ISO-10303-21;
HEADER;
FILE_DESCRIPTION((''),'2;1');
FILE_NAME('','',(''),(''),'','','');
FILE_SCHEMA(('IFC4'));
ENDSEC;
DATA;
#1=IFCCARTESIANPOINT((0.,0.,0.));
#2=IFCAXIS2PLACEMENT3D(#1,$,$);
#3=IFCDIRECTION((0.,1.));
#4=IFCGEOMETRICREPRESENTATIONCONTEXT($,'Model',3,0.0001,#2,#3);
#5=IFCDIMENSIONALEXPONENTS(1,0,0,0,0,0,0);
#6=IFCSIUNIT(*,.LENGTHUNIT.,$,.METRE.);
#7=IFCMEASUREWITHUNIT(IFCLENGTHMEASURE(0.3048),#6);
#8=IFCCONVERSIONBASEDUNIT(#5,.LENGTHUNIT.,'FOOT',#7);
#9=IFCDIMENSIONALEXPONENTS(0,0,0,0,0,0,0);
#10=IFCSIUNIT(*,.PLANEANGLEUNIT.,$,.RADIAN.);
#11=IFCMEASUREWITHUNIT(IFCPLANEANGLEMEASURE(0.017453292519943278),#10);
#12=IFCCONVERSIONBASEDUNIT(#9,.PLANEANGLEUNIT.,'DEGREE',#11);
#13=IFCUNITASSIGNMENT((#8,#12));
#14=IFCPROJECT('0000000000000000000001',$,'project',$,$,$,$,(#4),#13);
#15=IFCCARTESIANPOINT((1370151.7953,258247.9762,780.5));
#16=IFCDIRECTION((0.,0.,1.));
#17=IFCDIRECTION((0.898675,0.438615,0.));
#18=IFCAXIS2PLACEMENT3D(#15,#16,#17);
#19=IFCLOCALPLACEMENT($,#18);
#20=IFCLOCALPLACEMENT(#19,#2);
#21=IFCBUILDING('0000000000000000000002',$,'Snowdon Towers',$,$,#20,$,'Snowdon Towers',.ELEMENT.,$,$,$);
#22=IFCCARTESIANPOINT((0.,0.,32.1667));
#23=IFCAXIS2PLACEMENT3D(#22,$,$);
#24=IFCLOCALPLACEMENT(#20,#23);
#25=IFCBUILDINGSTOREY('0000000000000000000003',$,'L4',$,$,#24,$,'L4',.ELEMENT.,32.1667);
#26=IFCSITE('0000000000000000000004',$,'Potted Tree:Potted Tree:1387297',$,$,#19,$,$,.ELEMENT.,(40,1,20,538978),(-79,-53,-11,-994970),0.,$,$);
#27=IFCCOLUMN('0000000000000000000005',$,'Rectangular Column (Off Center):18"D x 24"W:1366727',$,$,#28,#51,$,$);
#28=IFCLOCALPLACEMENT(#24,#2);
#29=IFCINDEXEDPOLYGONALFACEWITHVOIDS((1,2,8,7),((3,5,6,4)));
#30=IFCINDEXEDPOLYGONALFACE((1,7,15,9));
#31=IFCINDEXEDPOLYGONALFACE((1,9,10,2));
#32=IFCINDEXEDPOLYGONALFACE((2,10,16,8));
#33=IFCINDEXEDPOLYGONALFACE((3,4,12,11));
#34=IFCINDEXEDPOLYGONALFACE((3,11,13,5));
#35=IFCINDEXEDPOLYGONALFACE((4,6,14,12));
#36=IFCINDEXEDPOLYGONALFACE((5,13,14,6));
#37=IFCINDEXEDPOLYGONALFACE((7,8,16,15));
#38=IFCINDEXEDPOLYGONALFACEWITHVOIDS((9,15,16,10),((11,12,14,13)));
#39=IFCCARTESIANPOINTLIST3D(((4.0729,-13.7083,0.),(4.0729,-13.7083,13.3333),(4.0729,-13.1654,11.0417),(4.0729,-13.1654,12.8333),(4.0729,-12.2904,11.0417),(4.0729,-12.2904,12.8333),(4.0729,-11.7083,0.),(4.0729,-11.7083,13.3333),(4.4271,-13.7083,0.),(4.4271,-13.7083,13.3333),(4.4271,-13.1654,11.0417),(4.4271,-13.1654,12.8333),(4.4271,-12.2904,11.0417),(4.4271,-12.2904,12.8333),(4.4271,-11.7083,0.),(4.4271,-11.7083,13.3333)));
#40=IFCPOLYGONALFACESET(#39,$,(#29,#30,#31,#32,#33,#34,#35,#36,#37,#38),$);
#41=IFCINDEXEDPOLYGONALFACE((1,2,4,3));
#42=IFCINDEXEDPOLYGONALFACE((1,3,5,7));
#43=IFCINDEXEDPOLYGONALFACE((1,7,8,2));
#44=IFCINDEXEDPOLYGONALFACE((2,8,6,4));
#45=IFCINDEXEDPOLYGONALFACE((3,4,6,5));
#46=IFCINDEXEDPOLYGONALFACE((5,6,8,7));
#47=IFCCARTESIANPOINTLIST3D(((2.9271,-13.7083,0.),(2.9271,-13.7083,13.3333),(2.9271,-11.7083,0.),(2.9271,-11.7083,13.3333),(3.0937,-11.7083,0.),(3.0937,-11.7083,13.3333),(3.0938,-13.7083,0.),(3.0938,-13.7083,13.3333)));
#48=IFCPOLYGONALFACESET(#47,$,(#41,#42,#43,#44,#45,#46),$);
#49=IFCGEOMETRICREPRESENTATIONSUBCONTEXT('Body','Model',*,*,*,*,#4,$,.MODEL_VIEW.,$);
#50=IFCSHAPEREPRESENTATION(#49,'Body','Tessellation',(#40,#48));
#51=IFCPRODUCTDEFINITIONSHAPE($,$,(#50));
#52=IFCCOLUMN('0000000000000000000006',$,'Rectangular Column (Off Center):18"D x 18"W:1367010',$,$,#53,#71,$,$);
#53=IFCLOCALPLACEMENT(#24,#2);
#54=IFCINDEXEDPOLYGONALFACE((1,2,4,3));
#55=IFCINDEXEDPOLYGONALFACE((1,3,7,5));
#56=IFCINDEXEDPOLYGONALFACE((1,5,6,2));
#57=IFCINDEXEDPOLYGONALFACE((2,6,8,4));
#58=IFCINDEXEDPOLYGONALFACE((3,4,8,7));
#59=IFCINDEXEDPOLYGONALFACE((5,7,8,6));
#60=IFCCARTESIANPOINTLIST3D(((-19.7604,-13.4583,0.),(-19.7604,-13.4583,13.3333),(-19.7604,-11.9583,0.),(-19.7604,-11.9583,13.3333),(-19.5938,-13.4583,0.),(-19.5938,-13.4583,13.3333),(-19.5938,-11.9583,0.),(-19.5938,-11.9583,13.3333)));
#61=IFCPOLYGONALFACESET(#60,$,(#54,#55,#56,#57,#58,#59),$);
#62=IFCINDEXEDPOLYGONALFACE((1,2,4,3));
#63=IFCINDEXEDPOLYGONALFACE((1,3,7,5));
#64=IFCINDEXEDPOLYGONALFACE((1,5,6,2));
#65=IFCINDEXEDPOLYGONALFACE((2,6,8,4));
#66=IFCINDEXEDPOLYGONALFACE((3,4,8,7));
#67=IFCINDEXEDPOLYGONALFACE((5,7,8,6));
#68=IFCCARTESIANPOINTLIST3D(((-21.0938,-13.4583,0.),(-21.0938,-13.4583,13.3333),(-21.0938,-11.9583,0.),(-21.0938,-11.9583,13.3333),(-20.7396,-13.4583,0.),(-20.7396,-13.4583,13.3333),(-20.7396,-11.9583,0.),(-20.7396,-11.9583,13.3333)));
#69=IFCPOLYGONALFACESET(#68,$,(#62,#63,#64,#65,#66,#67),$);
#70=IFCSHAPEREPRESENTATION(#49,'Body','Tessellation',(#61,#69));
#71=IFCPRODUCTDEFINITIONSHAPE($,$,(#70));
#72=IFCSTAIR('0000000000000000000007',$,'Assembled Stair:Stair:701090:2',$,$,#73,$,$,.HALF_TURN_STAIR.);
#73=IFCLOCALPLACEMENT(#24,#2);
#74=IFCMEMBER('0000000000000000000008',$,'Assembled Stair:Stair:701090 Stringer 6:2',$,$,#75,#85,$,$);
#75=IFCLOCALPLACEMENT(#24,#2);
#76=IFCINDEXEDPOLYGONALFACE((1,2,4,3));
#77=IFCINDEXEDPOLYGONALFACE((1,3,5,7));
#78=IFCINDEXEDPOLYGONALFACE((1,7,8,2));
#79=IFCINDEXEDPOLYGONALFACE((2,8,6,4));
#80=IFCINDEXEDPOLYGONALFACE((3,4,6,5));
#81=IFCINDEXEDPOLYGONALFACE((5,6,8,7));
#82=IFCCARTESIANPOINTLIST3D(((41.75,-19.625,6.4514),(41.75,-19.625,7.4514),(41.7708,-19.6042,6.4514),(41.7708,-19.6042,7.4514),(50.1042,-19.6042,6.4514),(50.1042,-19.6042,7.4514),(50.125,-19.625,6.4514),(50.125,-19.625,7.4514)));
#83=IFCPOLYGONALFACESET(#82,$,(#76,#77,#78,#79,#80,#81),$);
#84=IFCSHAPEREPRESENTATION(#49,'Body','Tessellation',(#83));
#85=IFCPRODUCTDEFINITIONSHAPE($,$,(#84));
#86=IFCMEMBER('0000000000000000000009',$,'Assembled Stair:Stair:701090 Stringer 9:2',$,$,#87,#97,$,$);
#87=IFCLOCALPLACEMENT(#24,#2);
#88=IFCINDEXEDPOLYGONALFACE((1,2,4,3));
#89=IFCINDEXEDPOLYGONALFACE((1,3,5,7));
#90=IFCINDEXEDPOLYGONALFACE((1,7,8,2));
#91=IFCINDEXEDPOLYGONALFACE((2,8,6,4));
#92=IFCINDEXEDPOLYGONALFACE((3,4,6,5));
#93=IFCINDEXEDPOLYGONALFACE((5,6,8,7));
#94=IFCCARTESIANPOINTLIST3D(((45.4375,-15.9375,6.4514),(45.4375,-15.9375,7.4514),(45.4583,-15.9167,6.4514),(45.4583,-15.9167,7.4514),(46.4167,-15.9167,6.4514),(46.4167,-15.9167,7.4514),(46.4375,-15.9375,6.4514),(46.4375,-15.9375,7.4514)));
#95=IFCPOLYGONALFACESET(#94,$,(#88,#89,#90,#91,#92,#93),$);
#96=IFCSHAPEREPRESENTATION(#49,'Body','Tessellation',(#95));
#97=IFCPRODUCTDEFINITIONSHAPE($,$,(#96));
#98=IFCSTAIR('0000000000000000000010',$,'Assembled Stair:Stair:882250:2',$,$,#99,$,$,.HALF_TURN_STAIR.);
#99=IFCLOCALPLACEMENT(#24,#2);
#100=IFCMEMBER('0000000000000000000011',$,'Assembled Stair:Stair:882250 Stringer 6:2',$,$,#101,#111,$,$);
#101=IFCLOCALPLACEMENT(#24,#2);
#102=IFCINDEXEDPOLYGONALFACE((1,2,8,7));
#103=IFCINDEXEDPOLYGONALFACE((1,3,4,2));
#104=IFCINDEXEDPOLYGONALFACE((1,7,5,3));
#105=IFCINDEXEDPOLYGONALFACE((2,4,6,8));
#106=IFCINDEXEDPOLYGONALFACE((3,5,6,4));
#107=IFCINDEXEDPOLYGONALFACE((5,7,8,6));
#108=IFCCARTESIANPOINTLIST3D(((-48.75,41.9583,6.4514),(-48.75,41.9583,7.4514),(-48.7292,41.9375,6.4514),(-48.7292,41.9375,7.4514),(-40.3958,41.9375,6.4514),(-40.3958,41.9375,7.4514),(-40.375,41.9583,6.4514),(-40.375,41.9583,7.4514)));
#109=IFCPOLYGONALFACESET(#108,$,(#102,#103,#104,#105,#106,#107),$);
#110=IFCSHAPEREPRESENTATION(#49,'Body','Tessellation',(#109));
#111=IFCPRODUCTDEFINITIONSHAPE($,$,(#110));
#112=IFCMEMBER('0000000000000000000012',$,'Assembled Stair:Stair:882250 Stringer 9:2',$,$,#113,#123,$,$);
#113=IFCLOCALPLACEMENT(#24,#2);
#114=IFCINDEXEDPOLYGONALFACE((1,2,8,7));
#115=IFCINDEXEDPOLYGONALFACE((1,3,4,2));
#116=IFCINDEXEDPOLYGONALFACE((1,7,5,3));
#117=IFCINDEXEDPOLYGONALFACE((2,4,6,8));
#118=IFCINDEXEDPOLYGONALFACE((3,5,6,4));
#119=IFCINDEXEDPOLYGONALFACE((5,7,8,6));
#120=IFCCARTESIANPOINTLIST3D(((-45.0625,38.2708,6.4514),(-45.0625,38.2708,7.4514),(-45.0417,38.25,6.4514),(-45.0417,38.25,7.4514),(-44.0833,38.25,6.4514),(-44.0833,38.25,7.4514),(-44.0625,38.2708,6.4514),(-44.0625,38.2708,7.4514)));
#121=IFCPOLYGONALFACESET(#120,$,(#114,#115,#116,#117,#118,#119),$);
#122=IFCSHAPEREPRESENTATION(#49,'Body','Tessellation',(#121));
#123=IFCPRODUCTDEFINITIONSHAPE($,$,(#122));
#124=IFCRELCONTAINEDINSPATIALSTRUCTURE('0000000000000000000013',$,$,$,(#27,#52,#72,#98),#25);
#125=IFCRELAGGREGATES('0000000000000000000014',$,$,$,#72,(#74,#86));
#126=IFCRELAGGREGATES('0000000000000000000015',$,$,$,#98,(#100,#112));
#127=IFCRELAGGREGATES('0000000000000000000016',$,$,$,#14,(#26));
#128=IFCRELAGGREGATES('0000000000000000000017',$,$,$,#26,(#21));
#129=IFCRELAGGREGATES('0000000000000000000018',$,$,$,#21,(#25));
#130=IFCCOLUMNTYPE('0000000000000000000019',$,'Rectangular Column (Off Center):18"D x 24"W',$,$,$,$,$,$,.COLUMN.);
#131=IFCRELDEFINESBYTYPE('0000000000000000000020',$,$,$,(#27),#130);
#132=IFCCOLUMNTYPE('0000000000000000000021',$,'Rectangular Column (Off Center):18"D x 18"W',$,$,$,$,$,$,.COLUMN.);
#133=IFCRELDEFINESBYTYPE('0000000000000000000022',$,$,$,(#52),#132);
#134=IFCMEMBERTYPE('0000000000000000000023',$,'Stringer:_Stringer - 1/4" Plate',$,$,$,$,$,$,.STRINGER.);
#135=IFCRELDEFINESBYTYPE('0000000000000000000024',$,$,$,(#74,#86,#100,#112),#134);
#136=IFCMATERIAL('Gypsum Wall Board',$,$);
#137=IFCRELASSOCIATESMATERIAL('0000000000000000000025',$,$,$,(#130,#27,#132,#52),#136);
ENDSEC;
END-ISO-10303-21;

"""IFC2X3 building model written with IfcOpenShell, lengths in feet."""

from ifc_helpers import new_model, entity, si_unit, converted_unit, direction, frame, frame_2d, origin, place, context, subcontext, project, spatial, polyline, rectangle, outline, extrude, source, transform, mapped, material, type_object, type_shapes, element, aggregate, save


model = new_model("IFC2X3")

# Units and contexts
model_context = context("Model", 3, precision=0.0001, world=origin(), true_north=direction((0.0, 1.0)))
body_context = subcontext(model_context, "Body", "Model", "MODEL_VIEW")
ifc_project = project(units=[converted_unit("LENGTHUNIT", "FOOT", entity("IfcLengthMeasure", 0.3048), si_unit("LENGTHUNIT", "METRE"), dimensions=[1, 0, 0, 0, 0, 0, 0]), converted_unit("PLANEANGLEUNIT", "DEGREE", entity("IfcPlaneAngleMeasure", 0.017453292519943278), si_unit("PLANEANGLEUNIT", "RADIAN"), dimensions=[0, 0, 0, 0, 0, 0, 0])], contexts=[model_context])

# Site, building, storey
site_placement = place(None, frame((1370151.7953, 258247.9762, 780.5), z_axis=(0.0, 0.0, 1.0), x_axis=(0.898675, 0.438615, 0.0)))
site = spatial("IfcSite", under=ifc_project, at=site_placement, Name="Potted Tree:Potted Tree:1387297", CompositionType="ELEMENT", RefLatitude=(40, 1, 20, 538978), RefLongitude=(-79, -53, -11, -994970), RefElevation=0.0)
building_placement = place(site_placement, origin())
building = spatial("IfcBuilding", under=site, at=building_placement, Name="Snowdon Towers", LongName="Snowdon Towers", CompositionType="ELEMENT")
storey_placement = place(building_placement, frame((0.0, 0.0, 32.1667)))
storey = spatial("IfcBuildingStorey", under=building, at=storey_placement, Name="L4", LongName="L4", CompositionType="ELEMENT", Elevation=32.1667)

# Shared definitions
ifc_material = material(Name="Gypsum Wall Board")

# Column, opening
column_type_1 = type_object("IfcColumnType", Name="Rectangular Column (Off Center):18\"D x 24\"W", PredefinedType="COLUMN", material=ifc_material)
shared_shape_1 = source(origin(), body_context, "Body", "SweptSolid", [
    extrude(rectangle(XDim=0.3542, YDim=2.0, at=frame_2d((0.0, 0.0), x_axis=(1.0, 0.0))), frame((4.25, -12.7083, 32.1667), z_axis=(0.0, 0.0, 1.0), x_axis=(-1.0, 0.0, 0.0)), (0.0, 0.0, 1.0), 13.3333),
    extrude(rectangle(XDim=0.1667, YDim=2.0, at=frame_2d((0.0, 0.0), x_axis=(1.0, 0.0))), frame((3.0104, -12.7083, 32.1667)), (0.0, 0.0, 1.0), 13.3333),
])
type_shapes(column_type_1, [shared_shape_1])
column_1_placement = place(storey_placement, frame((0.0, 0.0, -32.1667)))
column_1 = element("IfcColumn", 1, at=column_1_placement, inside=storey, type_object=column_type_1, material=ifc_material, Name="Rectangular Column (Off Center):18\"D x 24\"W:1366727", context=body_context, shape_type="MappedRepresentation", body=[
    mapped(shared_shape_1, transform((0.0, 0.0, 0.0), scale=1.0)),
])
opening_1_placement = place(storey_placement, frame((0.0, 0.0, -32.1667)))
element("IfcOpeningElement", 2, at=opening_1_placement, cuts=column_1, ObjectType="Opening", context=body_context, shape_type="SweptSolid", body=[
    extrude(rectangle(XDim=1.7917, YDim=0.875, at=frame_2d((0.0, 0.0), x_axis=(1.0, 0.0))), frame((4.4271, -12.7279, 44.1042), z_axis=(-1.0, 0.0, 0.0), x_axis=(0.0, 0.0, 1.0)), (0.0, 0.0, 1.0), 0.3542),
])

# Column
column_type_2 = type_object("IfcColumnType", Name="Rectangular Column (Off Center):18\"D x 18\"W", PredefinedType="COLUMN", material=ifc_material)
shared_shape_2 = source(origin(), body_context, "Body", "SweptSolid", [
    extrude(rectangle(XDim=0.1667, YDim=1.5, at=frame_2d((0.0, 0.0), x_axis=(1.0, 0.0))), frame((-19.6771, -12.7083, 32.1667), z_axis=(0.0, 0.0, 1.0), x_axis=(-1.0, 0.0, 0.0)), (0.0, 0.0, 1.0), 13.3333),
    extrude(rectangle(XDim=0.3542, YDim=1.5, at=frame_2d((0.0, 0.0), x_axis=(1.0, 0.0))), frame((-20.9167, -12.7083, 32.1667)), (0.0, 0.0, 1.0), 13.3333),
])
type_shapes(column_type_2, [shared_shape_2])
column_2_placement = place(storey_placement, frame((0.0, 0.0, -32.1667)))
element("IfcColumn", 3, at=column_2_placement, inside=storey, type_object=column_type_2, material=ifc_material, Name="Rectangular Column (Off Center):18\"D x 18\"W:1367010", context=body_context, shape_type="MappedRepresentation", body=[
    mapped(shared_shape_2, transform((0.0, 0.0, 0.0), scale=1.0)),
])

# Stair, members
stair_1_placement = place(storey_placement, origin())
stair_1 = element("IfcStair", 4, at=stair_1_placement, inside=storey, Name="Assembled Stair:Stair:701090:2", ShapeType="HALF_TURN_STAIR")
member_type = type_object("IfcMemberType", Name="Stringer:_Stringer - 1/4\" Plate", PredefinedType="STRINGER")
member_1_placement = place(stair_1_placement, origin())
member_1 = element("IfcMember", 5, at=member_1_placement, type_object=member_type, Name="Assembled Stair:Stair:701090 Stringer 6:2", context=body_context, shape_type="SweptSolid", body=[
    extrude(outline(polyline([(-4.1875, -0.0104), (4.1875, -0.0104), (4.1667, 0.0104), (-4.1667, 0.0104), (-4.1875, -0.0104)])), frame((45.9375, -19.6146, 6.4514)), (0.0, 0.0, 1.0), 1.0),
])
member_2_placement = place(stair_1_placement, origin())
member_2 = element("IfcMember", 6, at=member_2_placement, type_object=member_type, Name="Assembled Stair:Stair:701090 Stringer 9:2", context=body_context, shape_type="SweptSolid", body=[
    extrude(outline(polyline([(-0.4792, -0.0104), (0.4792, -0.0104), (0.5, 0.0104), (-0.5, 0.0104), (-0.4792, -0.0104)])), frame((45.9375, -15.9271, 6.4514), z_axis=(0.0, 0.0, 1.0), x_axis=(-1.0, 0.0, 0.0)), (0.0, 0.0, 1.0), 1.0),
])
aggregate(stair_1, [member_1, member_2])

# Stair, members
stair_2_placement = place(storey_placement, origin())
stair_2 = element("IfcStair", 7, at=stair_2_placement, inside=storey, Name="Assembled Stair:Stair:882250:2", ShapeType="HALF_TURN_STAIR")
member_3_placement = place(stair_2_placement, origin())
member_3 = element("IfcMember", 8, at=member_3_placement, type_object=member_type, Name="Assembled Stair:Stair:882250 Stringer 6:2", context=body_context, shape_type="SweptSolid", body=[
    extrude(outline(polyline([(-4.1875, -0.0104), (4.1875, -0.0104), (4.1667, 0.0104), (-4.1667, 0.0104), (-4.1875, -0.0104)])), frame((-44.5625, 41.9479, 6.4514), z_axis=(0.0, 0.0, 1.0), x_axis=(-1.0, 0.0, 0.0)), (0.0, 0.0, 1.0), 1.0),
])
member_4_placement = place(stair_2_placement, origin())
member_4 = element("IfcMember", 9, at=member_4_placement, type_object=member_type, Name="Assembled Stair:Stair:882250 Stringer 9:2", context=body_context, shape_type="SweptSolid", body=[
    extrude(outline(polyline([(-0.4792, -0.0104), (0.4792, -0.0104), (0.5, 0.0104), (-0.5, 0.0104), (-0.4792, -0.0104)])), frame((-44.5625, 38.2604, 6.4514)), (0.0, 0.0, 1.0), 1.0),
])
aggregate(stair_2, [member_3, member_4])

save(model, "model.ifc")
